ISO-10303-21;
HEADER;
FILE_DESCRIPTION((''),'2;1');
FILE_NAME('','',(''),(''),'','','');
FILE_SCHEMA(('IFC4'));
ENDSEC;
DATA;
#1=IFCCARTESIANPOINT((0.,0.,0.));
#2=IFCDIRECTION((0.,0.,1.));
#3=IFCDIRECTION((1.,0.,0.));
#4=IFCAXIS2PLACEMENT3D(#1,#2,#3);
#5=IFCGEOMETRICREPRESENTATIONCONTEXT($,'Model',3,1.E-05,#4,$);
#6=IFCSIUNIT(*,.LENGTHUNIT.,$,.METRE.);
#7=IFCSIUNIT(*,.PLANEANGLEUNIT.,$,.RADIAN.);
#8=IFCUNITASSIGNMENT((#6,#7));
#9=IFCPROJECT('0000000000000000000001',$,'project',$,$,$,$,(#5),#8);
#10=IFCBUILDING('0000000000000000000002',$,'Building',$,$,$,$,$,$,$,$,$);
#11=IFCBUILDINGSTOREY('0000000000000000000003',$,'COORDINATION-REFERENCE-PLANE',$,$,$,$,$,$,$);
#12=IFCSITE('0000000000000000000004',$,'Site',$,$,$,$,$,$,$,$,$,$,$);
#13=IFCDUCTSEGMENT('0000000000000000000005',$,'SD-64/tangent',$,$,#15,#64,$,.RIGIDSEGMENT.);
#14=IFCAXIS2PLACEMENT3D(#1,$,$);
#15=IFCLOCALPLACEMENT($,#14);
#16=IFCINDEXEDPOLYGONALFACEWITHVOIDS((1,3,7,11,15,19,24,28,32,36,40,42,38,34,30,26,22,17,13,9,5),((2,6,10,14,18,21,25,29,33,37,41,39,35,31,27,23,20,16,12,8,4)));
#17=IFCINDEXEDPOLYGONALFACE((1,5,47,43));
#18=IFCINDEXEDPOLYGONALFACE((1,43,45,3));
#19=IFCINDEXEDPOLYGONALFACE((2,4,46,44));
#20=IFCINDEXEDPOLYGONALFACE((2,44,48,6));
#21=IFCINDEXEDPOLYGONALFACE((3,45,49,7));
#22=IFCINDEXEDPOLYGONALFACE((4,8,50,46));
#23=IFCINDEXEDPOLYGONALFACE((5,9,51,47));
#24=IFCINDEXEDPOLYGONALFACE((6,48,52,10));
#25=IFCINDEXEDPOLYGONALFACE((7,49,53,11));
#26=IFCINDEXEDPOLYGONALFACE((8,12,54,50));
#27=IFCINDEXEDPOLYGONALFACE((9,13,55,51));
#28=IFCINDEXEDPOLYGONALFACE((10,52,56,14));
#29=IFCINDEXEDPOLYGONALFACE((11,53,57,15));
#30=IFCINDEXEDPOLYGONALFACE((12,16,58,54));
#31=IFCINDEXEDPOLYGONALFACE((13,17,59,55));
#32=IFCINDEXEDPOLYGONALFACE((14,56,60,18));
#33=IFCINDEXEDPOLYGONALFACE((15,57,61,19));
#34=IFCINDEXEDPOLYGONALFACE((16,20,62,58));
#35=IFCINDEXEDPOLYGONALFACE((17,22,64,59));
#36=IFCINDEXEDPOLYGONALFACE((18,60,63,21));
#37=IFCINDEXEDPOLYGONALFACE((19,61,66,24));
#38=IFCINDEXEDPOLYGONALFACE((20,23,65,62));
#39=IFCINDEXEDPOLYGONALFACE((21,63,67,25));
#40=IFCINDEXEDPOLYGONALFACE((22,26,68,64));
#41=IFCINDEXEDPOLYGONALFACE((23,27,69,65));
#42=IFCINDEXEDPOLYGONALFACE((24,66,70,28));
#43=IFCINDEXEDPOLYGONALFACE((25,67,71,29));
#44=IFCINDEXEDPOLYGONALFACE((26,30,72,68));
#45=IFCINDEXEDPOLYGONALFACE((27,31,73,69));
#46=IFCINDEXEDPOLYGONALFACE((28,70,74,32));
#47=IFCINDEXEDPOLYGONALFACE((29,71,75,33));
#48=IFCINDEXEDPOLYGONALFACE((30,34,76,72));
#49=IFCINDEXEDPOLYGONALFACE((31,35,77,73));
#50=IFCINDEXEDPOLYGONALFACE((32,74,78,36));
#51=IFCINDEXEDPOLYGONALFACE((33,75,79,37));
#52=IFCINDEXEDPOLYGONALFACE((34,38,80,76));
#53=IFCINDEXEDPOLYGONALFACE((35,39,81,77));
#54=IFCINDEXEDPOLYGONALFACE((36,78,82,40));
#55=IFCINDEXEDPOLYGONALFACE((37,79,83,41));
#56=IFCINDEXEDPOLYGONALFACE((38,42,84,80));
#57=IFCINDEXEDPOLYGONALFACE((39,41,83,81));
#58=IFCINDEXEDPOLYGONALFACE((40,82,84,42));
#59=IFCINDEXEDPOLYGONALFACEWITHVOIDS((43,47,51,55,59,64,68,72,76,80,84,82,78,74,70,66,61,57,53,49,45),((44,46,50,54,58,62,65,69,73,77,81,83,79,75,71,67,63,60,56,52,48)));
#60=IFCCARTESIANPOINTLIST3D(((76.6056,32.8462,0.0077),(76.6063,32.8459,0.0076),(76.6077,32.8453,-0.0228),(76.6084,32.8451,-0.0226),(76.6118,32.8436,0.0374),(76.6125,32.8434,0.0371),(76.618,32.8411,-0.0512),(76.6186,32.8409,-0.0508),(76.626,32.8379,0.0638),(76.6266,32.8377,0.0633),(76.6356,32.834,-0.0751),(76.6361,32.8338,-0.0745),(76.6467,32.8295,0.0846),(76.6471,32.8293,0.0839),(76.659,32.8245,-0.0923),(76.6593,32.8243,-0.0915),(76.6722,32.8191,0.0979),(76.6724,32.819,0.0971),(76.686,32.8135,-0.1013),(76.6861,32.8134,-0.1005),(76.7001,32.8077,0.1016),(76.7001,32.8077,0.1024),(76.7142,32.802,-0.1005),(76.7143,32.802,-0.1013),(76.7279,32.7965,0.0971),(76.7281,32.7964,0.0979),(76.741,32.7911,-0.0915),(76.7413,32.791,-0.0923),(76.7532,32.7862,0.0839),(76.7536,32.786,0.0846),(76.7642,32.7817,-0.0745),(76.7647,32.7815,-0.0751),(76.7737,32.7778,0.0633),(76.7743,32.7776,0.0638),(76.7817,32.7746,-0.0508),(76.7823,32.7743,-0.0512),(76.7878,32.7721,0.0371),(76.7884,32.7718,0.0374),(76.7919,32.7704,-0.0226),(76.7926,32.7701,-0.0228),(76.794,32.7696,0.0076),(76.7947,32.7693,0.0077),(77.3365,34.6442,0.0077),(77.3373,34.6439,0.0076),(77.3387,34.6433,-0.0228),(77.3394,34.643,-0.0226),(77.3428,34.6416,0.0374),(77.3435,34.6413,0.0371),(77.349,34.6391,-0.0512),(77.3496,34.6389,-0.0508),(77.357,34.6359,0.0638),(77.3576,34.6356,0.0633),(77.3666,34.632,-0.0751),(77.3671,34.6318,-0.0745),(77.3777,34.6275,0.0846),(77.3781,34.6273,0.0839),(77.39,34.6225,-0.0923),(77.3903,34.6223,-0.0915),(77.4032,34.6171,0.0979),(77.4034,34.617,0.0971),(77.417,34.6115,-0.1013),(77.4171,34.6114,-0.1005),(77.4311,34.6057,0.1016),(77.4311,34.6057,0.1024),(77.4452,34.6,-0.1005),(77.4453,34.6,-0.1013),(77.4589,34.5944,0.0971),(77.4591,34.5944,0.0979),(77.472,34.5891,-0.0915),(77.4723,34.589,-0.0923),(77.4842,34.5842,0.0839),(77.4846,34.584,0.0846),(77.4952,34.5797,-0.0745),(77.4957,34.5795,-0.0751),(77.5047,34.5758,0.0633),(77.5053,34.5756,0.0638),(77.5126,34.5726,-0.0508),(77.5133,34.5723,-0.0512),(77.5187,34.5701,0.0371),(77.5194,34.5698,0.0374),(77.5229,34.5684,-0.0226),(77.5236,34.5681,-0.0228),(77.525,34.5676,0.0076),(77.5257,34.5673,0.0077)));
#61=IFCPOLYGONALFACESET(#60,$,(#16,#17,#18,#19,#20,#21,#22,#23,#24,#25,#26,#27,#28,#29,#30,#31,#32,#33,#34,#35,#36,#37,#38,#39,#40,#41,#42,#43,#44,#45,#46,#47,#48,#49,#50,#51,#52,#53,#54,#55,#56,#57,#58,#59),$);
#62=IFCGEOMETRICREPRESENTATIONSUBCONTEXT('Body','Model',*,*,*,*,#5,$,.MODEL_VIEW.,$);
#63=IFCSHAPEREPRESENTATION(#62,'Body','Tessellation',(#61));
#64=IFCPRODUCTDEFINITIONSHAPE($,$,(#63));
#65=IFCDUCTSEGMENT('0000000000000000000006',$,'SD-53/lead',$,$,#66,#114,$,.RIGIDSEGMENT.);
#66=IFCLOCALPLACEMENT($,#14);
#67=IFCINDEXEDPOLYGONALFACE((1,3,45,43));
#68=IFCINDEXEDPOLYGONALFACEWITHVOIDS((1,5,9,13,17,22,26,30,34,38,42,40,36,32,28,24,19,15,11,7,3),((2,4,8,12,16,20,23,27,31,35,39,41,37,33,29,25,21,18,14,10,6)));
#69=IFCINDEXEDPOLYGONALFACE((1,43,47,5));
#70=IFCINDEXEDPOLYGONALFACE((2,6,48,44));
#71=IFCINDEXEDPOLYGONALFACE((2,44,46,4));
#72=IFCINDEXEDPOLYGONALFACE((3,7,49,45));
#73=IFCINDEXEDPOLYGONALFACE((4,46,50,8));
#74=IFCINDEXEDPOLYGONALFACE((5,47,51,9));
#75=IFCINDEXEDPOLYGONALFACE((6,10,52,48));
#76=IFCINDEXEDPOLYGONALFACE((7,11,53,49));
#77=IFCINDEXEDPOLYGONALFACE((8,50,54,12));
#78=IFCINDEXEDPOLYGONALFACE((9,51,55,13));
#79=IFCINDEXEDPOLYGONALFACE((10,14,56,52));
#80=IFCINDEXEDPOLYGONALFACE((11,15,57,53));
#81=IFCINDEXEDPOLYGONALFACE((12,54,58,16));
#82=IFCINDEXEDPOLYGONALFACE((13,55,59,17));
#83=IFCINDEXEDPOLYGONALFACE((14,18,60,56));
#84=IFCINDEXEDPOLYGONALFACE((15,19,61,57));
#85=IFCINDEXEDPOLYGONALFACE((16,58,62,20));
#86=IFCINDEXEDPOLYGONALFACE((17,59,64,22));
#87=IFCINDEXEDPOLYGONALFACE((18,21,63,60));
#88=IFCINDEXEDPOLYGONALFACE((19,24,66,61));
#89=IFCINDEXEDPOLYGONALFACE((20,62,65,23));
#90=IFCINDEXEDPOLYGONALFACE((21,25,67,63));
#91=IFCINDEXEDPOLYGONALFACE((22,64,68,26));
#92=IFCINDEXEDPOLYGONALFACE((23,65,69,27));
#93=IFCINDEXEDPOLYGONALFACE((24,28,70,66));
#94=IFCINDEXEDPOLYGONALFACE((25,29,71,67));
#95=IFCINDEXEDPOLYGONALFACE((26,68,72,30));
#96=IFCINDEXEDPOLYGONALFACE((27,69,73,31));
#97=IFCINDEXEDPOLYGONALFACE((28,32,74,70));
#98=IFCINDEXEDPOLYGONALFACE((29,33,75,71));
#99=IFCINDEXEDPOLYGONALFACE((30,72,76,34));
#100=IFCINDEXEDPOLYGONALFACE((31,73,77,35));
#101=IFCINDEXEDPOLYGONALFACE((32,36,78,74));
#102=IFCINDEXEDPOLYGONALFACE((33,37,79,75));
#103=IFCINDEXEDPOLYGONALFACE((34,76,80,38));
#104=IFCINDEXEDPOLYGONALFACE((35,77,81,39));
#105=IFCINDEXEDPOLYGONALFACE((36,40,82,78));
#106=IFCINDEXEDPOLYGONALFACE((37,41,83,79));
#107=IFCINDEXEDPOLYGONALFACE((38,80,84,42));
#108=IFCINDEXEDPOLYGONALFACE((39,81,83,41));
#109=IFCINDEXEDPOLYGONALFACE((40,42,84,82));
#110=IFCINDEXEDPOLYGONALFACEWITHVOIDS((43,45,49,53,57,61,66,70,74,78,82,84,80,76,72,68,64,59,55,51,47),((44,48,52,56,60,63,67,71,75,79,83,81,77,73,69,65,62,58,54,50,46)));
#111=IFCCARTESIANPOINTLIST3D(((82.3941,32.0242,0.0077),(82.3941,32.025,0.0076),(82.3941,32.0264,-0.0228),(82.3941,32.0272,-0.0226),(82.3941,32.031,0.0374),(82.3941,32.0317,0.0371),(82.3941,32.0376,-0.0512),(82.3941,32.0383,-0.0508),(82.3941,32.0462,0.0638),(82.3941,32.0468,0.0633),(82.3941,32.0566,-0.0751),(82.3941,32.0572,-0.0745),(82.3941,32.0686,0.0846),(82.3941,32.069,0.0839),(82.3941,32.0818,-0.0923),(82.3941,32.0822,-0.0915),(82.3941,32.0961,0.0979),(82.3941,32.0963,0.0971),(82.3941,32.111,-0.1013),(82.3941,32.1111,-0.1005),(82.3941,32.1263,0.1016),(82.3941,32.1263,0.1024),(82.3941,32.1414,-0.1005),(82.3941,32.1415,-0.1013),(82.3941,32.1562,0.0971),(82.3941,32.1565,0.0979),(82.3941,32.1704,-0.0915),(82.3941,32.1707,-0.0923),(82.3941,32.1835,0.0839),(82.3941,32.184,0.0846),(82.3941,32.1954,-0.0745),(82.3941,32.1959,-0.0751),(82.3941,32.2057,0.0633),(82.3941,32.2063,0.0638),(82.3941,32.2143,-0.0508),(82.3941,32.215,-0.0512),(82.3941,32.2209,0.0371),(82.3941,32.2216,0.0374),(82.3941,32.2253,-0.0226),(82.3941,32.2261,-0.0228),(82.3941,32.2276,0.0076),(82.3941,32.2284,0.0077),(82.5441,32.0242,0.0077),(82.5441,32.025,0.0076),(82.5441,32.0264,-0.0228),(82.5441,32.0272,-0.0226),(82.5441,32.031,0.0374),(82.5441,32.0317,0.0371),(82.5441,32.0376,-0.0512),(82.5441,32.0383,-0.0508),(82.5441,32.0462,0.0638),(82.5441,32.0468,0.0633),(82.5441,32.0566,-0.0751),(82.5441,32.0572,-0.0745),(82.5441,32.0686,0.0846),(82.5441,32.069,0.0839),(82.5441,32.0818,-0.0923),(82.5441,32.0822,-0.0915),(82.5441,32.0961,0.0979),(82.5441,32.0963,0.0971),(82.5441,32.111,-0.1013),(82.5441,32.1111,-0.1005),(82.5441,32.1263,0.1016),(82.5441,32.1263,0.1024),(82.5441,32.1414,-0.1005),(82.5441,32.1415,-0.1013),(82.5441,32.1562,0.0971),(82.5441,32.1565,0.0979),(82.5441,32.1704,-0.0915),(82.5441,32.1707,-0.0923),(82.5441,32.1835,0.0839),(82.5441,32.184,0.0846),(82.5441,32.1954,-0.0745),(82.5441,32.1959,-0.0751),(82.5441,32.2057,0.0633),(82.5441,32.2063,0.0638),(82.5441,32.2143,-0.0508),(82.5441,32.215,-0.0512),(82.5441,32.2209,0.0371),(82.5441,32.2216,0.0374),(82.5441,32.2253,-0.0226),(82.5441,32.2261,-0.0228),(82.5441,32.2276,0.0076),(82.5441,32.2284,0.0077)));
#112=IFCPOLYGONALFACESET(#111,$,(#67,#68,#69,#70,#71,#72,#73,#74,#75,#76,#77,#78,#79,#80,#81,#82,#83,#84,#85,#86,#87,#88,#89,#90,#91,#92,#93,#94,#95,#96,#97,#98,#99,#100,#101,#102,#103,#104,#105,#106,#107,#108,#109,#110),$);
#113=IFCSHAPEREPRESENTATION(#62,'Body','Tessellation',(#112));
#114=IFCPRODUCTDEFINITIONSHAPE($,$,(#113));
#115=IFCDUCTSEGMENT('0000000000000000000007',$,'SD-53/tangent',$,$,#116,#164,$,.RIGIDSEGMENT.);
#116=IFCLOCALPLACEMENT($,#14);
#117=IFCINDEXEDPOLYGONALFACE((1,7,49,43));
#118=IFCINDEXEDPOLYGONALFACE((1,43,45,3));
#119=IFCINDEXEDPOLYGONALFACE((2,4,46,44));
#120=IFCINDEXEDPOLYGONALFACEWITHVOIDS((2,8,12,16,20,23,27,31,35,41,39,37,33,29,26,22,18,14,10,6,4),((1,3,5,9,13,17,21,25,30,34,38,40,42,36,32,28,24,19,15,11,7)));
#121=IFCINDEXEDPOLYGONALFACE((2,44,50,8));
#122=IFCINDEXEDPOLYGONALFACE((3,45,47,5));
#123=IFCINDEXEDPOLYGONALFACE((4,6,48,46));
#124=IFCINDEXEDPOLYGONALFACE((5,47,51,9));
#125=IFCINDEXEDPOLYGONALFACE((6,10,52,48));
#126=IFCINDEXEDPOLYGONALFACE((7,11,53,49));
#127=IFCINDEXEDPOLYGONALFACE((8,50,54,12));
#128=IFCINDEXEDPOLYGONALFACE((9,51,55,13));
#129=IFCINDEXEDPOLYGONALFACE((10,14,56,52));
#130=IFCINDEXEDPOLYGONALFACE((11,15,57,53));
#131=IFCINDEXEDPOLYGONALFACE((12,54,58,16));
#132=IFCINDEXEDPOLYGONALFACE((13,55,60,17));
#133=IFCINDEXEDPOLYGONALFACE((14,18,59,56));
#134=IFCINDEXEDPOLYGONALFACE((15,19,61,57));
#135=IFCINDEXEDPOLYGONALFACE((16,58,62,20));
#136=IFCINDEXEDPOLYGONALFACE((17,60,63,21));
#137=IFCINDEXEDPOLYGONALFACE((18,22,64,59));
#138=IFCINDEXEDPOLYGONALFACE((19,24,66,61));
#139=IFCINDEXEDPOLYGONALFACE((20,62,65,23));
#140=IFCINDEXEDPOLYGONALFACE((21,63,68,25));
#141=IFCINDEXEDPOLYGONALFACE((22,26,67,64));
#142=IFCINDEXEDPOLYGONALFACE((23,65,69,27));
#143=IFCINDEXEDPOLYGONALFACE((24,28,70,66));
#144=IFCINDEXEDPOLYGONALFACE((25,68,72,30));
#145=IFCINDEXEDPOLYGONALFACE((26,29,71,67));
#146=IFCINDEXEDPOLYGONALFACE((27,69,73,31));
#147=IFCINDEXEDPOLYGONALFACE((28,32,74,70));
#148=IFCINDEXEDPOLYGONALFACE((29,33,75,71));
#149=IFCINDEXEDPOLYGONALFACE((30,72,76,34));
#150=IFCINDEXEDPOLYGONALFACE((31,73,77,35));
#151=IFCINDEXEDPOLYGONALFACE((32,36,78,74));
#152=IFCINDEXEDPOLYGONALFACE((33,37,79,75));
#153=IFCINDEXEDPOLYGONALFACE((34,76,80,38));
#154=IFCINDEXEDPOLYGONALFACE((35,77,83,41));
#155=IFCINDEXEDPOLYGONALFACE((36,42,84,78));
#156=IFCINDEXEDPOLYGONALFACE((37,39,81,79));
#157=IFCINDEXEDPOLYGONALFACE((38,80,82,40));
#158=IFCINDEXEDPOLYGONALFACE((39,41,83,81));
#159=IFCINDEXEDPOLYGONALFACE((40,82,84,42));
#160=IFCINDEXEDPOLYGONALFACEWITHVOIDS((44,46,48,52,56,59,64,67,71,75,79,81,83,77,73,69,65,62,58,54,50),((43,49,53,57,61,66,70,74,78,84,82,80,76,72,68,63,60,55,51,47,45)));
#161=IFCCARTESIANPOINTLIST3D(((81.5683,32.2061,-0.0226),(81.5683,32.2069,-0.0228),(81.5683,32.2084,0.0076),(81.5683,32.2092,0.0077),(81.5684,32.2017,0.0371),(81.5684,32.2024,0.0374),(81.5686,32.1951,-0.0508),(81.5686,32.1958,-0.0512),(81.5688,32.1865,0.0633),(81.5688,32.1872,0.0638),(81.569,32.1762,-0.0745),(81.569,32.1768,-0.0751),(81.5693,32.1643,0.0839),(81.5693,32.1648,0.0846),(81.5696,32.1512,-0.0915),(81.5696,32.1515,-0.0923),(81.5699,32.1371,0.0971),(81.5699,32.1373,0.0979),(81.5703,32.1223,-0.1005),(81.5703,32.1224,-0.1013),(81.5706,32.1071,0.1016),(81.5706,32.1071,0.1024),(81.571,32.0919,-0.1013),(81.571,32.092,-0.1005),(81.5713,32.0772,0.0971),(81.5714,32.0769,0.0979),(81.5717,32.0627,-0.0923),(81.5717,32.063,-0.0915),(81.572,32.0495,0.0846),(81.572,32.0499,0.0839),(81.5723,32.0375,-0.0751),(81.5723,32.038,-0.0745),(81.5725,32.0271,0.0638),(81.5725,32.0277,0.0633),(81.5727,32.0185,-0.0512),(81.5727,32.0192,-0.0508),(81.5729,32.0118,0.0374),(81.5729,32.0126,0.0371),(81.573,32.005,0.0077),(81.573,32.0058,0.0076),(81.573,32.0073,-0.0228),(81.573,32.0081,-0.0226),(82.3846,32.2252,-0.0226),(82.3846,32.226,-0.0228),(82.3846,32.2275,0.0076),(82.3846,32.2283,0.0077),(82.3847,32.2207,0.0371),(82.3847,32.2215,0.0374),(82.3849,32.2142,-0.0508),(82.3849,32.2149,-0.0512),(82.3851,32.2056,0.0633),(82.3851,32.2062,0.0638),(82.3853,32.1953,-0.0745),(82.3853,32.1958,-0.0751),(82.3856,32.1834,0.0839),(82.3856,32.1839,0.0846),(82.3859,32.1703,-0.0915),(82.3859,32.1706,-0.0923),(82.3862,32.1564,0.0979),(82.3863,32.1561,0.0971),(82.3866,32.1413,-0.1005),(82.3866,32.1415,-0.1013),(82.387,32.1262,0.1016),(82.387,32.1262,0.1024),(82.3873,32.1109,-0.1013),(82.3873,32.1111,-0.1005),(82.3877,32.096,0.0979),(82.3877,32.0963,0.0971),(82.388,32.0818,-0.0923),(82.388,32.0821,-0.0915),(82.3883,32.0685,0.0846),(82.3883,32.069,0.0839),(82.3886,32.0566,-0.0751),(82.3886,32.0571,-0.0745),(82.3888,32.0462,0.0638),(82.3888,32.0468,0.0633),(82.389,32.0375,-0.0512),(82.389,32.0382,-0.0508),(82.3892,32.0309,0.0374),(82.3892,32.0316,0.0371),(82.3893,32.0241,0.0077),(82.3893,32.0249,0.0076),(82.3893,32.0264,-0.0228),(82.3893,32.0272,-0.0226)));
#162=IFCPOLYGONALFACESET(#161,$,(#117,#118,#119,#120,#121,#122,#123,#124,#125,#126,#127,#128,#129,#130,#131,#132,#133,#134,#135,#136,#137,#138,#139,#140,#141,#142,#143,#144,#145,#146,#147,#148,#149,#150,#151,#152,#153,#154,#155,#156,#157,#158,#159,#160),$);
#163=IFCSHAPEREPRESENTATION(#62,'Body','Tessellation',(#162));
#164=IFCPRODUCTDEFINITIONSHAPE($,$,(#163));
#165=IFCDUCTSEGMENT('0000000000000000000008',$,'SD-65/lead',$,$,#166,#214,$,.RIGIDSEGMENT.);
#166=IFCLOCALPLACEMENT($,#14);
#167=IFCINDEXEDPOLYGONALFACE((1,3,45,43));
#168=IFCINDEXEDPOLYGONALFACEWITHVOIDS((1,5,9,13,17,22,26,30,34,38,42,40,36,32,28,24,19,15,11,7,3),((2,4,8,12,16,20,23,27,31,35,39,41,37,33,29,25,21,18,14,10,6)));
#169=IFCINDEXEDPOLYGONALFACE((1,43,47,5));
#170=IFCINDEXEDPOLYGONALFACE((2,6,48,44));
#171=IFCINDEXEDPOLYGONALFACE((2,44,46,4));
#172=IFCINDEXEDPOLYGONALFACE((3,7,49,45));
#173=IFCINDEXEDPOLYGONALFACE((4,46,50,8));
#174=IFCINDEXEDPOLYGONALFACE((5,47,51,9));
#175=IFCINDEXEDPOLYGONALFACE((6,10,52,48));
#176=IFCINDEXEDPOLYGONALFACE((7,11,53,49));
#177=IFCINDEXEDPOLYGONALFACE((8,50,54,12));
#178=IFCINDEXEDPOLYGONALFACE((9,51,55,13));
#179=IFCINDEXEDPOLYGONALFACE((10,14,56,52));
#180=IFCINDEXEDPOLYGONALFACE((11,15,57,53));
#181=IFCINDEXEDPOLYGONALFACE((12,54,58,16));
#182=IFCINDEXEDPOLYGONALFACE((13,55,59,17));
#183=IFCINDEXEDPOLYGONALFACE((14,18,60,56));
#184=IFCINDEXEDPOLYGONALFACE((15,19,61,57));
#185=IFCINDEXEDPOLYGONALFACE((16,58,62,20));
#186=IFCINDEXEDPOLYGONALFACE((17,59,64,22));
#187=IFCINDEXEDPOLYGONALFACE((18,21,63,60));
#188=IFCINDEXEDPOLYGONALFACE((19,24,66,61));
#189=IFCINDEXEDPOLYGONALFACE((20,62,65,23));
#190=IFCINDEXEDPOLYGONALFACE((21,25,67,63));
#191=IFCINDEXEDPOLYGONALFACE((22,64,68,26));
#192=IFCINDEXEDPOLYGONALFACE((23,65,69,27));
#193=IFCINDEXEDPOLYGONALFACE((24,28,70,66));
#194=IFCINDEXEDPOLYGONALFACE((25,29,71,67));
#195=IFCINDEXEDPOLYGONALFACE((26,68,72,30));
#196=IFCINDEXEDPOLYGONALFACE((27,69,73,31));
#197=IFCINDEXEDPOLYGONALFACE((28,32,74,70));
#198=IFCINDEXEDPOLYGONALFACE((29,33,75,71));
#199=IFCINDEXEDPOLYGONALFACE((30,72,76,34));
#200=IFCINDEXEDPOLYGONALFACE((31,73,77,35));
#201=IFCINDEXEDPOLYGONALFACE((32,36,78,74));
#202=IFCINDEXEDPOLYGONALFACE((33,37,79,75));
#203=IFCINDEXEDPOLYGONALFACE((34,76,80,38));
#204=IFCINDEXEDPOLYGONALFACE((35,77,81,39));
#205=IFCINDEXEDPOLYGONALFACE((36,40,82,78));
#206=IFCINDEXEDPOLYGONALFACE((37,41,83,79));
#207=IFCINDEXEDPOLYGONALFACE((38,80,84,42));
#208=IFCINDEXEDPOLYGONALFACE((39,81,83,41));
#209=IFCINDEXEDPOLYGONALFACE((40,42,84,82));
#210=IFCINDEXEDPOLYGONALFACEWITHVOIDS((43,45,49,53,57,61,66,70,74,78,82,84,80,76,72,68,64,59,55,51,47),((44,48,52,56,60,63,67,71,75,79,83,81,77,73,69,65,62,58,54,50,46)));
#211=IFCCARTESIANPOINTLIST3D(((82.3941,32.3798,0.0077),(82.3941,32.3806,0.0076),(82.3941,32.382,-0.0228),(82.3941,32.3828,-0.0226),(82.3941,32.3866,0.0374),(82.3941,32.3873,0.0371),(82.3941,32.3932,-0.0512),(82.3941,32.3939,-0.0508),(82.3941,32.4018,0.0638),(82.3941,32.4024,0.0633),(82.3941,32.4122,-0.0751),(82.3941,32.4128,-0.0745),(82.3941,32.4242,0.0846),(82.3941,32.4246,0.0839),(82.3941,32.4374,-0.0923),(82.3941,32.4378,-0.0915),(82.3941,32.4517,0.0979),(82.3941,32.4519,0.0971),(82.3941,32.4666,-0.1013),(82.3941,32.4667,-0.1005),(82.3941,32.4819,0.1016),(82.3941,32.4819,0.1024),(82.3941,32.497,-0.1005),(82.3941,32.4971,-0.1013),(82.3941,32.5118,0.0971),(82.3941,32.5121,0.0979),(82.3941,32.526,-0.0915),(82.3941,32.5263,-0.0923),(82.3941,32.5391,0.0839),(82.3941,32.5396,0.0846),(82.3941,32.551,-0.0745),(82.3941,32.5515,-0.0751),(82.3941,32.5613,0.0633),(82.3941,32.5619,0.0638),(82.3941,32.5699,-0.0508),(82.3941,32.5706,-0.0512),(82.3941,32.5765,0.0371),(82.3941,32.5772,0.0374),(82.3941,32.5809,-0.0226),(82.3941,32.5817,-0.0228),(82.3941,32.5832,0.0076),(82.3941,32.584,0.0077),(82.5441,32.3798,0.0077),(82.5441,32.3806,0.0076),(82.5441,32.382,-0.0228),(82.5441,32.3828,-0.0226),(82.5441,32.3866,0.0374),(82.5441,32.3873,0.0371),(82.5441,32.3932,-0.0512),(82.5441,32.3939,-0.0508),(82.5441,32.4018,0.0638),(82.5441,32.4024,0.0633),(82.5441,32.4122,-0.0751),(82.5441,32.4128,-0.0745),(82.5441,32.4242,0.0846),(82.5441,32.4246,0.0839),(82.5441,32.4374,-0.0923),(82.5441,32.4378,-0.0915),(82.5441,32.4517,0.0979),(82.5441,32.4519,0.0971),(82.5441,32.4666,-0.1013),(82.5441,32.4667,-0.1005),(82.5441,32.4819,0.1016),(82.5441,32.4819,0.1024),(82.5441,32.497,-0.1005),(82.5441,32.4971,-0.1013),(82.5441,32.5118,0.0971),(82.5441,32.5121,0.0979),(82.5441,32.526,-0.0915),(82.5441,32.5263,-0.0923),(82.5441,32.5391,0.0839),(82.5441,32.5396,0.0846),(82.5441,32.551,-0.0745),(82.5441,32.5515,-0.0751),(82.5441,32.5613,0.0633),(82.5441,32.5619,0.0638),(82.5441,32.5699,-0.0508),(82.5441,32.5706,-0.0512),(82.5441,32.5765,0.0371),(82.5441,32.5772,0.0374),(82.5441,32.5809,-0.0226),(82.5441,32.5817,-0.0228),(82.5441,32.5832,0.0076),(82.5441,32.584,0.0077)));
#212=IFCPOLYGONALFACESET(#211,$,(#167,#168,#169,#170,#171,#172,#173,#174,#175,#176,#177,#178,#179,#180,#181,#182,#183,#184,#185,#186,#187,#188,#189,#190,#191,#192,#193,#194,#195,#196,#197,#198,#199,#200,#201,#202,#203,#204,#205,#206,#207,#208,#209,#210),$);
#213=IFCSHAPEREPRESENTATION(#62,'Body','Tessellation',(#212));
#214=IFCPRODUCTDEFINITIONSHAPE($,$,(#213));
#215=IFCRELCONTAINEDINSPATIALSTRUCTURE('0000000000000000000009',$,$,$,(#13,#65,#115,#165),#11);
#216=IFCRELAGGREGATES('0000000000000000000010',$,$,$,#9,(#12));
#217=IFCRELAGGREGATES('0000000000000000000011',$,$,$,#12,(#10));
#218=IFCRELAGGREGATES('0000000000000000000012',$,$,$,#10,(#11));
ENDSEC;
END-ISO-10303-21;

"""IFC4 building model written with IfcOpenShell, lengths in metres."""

from ifc_helpers import new_model, si_unit, frame, origin_with_axes, place, context, subcontext, project, spatial, hollow_circle, extrude, element, save


model = new_model("IFC4")

# Units and contexts
model_context = context("Model", 3, precision=1e-05, world=origin_with_axes())
body_context_1 = subcontext(model_context, "Body", "Model", "MODEL_VIEW")
ifc_project = project(units=[si_unit("LENGTHUNIT", "METRE"), si_unit("PLANEANGLEUNIT", "RADIAN")], contexts=[model_context])

# Site, building, storey
site = spatial("IfcSite", under=ifc_project, Name="Site")
building = spatial("IfcBuilding", under=site, Name="Building")
storey = spatial("IfcBuildingStorey", under=building, Name="COORDINATION-REFERENCE-PLANE")

# Duct segment
duct_segment_1_placement = place(None, frame((76.7001, 32.8077, 0.0), z_axis=(0.376625, 0.926366, 0.0), x_axis=(0.0, 0.0, 1.0)))
element("IfcDuctSegment", 1, at=duct_segment_1_placement, inside=storey, Name="SD-64/tangent", PredefinedType="RIGIDSEGMENT", context=body_context_1, shape_type="SweptSolid", body=[
    extrude(hollow_circle(Radius=0.1024, WallThickness=0.0008), origin_with_axes(), (0.0, 0.0, 1.0), 1.9409),
])

# Duct segment
duct_segment_2_placement = place(None, frame((82.5441, 32.1263, 0.0), z_axis=(-1.0, 0.0, 0.0), x_axis=(0.0, 0.0, 1.0)))
element("IfcDuctSegment", 2, at=duct_segment_2_placement, inside=storey, Name="SD-53/lead", PredefinedType="RIGIDSEGMENT", context=body_context_1, shape_type="SweptSolid", body=[
    extrude(hollow_circle(Radius=0.1024, WallThickness=0.0008), origin_with_axes(), (0.0, 0.0, 1.0), 0.15),
])

# Duct segment
duct_segment_3_placement = place(None, frame((82.387, 32.1262, 0.0), z_axis=(-0.999727, -0.023361, 0.0), x_axis=(0.0, 0.0, 1.0)))
element("IfcDuctSegment", 3, at=duct_segment_3_placement, inside=storey, Name="SD-53/tangent", PredefinedType="RIGIDSEGMENT", context=body_context_1, shape_type="SweptSolid", body=[
    extrude(hollow_circle(Radius=0.1024, WallThickness=0.0008), origin_with_axes(), (0.0, 0.0, 1.0), 0.8165),
])

# Duct segment
duct_segment_4_placement = place(None, frame((82.5441, 32.4819, 0.0), z_axis=(-1.0, 0.0, 0.0), x_axis=(0.0, 0.0, 1.0)))
element("IfcDuctSegment", 4, at=duct_segment_4_placement, inside=storey, Name="SD-65/lead", PredefinedType="RIGIDSEGMENT", context=body_context_1, shape_type="SweptSolid", body=[
    extrude(hollow_circle(Radius=0.1024, WallThickness=0.0008), origin_with_axes(), (0.0, 0.0, 1.0), 0.15),
])

save(model, "model.ifc")
